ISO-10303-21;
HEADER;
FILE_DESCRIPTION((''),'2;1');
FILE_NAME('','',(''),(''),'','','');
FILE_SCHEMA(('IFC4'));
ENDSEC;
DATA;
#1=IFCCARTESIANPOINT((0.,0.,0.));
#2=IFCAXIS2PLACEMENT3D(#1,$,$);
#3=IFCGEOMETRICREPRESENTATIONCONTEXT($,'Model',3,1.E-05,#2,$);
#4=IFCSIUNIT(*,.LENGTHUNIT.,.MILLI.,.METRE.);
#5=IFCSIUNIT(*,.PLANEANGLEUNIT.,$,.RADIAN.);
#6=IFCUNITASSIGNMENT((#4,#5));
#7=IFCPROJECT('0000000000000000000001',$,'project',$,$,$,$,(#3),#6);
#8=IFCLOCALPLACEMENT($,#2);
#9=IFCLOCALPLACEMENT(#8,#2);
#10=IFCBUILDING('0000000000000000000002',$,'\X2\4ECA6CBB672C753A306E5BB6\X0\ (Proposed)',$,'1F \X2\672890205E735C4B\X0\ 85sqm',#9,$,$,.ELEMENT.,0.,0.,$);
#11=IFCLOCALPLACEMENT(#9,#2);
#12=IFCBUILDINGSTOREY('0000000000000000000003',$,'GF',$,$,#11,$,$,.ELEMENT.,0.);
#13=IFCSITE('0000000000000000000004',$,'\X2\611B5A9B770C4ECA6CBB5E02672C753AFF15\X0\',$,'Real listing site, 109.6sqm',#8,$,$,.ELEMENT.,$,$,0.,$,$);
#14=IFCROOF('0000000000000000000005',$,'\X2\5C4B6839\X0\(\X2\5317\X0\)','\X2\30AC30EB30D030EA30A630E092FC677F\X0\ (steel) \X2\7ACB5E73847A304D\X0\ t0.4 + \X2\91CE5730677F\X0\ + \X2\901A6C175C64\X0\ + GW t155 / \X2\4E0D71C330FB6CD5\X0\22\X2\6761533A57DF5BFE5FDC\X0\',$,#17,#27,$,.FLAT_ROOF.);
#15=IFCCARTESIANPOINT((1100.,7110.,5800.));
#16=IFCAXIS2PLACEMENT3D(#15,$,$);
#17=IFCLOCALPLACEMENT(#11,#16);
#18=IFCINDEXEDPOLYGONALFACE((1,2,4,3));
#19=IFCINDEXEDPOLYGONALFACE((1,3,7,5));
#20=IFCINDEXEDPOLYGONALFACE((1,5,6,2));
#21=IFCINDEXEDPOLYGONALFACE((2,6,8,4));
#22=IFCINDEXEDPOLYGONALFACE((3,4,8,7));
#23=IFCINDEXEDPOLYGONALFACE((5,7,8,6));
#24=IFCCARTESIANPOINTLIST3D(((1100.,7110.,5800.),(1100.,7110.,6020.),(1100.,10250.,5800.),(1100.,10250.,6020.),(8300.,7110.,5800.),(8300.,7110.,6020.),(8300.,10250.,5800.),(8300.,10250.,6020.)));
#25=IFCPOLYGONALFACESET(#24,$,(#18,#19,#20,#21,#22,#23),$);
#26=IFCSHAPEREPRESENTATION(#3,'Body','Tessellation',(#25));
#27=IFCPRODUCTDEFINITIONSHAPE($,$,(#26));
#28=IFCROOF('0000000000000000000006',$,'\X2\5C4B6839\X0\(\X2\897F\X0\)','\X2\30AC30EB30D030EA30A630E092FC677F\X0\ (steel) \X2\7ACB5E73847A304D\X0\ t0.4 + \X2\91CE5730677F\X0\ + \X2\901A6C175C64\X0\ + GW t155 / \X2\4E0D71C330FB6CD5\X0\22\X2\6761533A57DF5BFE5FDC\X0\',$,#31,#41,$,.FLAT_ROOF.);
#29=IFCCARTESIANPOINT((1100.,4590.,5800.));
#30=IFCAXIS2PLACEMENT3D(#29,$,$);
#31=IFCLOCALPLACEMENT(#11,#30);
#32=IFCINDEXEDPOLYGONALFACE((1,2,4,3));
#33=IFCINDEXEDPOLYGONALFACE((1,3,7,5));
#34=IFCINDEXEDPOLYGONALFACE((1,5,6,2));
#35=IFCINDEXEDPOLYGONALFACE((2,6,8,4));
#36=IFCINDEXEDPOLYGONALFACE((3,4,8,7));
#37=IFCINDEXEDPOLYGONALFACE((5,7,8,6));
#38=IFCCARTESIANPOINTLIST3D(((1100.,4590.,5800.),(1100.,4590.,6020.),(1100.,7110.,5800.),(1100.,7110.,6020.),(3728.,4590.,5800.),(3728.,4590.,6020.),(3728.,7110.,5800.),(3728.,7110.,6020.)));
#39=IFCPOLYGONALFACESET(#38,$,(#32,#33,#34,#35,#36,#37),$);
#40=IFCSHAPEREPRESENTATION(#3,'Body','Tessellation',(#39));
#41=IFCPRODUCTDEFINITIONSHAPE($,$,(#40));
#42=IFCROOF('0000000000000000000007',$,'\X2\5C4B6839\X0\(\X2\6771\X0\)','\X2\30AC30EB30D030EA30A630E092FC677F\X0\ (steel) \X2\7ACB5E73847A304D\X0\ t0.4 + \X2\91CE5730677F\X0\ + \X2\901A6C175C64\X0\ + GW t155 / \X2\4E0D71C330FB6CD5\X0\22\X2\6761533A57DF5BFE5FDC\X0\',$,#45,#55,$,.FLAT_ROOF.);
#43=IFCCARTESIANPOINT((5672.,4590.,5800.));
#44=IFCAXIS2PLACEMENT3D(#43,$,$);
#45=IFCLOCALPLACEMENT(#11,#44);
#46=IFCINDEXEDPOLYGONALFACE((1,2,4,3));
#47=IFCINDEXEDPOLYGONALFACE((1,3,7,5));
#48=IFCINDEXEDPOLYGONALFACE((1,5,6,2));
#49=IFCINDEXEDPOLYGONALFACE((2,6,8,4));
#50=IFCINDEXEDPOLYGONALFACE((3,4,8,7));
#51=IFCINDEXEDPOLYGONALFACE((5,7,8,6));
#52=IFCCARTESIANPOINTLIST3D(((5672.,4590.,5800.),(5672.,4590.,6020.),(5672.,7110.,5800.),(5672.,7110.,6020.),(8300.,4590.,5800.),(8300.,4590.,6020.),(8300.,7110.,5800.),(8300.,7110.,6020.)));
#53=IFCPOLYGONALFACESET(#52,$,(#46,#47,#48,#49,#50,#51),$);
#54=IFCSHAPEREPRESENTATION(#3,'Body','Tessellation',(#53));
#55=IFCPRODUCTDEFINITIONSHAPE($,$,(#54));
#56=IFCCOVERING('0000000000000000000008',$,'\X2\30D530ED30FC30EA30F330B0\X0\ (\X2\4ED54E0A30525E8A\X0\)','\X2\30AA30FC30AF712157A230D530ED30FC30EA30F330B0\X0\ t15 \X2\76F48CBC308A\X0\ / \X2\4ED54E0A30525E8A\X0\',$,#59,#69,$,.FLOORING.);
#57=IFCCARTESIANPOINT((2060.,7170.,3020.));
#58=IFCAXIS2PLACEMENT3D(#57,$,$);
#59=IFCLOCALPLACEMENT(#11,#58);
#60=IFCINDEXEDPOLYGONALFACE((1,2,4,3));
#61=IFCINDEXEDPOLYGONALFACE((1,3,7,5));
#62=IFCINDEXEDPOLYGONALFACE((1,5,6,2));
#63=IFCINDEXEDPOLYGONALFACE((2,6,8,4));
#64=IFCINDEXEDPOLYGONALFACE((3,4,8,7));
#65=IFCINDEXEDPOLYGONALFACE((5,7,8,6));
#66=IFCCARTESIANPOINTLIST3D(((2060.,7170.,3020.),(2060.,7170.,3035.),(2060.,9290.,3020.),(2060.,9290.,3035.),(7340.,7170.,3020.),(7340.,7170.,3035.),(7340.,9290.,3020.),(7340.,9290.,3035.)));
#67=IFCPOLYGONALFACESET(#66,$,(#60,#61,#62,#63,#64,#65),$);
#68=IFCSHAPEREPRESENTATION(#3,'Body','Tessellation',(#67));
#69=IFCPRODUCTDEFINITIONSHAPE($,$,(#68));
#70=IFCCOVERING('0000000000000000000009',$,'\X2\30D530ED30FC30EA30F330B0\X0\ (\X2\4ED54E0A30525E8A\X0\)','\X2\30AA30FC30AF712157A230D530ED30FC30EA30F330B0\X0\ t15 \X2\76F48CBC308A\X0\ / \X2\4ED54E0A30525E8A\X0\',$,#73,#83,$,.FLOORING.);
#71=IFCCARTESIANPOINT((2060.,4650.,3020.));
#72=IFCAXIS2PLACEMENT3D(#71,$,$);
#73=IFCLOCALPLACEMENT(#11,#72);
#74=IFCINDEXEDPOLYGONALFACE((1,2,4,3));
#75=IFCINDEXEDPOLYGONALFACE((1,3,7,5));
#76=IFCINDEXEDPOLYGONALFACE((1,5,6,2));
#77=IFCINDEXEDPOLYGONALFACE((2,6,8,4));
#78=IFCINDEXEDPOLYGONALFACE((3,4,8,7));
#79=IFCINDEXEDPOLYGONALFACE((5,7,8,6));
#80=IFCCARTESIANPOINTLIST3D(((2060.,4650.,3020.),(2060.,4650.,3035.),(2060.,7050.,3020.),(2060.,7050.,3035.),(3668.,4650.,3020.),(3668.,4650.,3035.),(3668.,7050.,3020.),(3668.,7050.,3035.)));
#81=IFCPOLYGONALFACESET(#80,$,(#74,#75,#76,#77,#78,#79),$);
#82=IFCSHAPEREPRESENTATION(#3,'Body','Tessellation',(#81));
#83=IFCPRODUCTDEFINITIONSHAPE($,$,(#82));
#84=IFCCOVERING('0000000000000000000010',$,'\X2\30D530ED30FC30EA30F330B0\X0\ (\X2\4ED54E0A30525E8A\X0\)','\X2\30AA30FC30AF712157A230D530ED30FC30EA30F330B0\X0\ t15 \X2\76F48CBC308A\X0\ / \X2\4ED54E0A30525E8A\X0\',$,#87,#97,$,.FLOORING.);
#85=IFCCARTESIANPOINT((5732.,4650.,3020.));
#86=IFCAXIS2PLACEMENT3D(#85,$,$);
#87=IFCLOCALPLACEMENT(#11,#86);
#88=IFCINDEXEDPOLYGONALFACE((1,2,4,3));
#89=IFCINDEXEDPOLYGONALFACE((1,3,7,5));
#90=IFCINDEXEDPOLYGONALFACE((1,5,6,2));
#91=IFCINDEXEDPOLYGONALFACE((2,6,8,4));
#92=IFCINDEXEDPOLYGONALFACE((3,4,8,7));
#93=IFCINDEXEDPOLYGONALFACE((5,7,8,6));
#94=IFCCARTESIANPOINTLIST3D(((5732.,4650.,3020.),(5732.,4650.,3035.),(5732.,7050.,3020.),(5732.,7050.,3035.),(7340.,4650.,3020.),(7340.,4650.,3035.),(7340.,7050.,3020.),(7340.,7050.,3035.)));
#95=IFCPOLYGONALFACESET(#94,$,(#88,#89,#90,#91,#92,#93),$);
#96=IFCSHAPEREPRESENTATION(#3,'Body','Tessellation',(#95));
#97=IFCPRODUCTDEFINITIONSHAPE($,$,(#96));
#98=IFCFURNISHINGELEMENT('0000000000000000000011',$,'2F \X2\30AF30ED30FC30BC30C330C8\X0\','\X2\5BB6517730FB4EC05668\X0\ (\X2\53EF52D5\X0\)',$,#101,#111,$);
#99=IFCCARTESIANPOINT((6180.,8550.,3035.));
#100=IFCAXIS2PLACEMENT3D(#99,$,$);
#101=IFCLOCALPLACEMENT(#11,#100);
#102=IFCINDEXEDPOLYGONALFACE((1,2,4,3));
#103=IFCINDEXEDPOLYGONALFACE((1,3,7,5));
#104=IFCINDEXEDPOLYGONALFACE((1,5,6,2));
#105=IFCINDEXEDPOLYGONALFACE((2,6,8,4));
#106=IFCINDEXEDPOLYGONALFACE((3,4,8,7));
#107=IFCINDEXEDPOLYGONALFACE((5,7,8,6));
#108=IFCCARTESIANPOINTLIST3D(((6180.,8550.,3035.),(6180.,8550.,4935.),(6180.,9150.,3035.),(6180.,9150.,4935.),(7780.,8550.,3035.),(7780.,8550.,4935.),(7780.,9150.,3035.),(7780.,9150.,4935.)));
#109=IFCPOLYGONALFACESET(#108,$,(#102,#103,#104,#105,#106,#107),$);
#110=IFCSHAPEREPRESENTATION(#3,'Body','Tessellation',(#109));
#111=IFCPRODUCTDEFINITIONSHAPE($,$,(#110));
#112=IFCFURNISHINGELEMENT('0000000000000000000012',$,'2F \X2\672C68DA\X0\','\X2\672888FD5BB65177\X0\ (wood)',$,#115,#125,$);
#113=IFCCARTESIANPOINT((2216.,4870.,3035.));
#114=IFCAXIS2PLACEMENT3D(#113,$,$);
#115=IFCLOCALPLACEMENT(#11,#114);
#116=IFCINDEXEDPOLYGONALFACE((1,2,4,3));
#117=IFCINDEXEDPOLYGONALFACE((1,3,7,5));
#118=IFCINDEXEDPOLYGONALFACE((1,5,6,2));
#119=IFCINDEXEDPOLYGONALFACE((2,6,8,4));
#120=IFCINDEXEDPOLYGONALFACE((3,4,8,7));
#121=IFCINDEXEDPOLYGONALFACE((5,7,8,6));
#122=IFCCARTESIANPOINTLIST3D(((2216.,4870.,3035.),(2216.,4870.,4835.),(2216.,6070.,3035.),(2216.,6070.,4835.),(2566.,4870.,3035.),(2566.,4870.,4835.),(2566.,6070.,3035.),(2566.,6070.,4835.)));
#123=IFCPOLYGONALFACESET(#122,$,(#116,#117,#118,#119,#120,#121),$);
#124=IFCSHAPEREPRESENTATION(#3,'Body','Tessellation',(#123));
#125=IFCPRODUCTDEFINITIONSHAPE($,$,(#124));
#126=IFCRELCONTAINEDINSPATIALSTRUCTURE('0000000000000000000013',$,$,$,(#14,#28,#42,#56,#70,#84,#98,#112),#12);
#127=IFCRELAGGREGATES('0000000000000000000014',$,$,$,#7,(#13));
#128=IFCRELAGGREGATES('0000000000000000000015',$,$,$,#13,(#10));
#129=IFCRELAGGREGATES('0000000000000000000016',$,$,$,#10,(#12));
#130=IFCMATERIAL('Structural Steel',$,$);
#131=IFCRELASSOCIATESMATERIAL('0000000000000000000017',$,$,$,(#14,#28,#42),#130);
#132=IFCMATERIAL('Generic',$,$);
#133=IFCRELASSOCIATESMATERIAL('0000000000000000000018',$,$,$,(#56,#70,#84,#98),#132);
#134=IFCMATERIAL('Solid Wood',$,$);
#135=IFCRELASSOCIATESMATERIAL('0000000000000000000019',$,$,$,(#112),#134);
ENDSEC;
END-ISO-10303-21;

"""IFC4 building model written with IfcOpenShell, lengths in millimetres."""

from ifc_helpers import new_model, si_unit, frame, frame_2d, origin, place, context, project, spatial, rectangle, extrude, material, element, save


model = new_model("IFC4")

# Units and contexts
model_context = context("Model", 3, precision=1e-05, world=origin())
ifc_project = project(units=[si_unit("LENGTHUNIT", "METRE", prefix="MILLI"), si_unit("PLANEANGLEUNIT", "RADIAN")], contexts=[model_context])

# Site, building, storey
site_placement = place(None, origin())
site = spatial("IfcSite", under=ifc_project, at=site_placement, Name="愛媛県今治市本町５", ObjectType="Real listing site, 109.6sqm", CompositionType="ELEMENT", RefElevation=0.0)
building_placement = place(site_placement, origin())
building = spatial("IfcBuilding", under=site, at=building_placement, Name="今治本町の家 (Proposed)", ObjectType="1F 木造平屋 85sqm", CompositionType="ELEMENT", ElevationOfRefHeight=0.0, ElevationOfTerrain=0.0)
storey_placement = place(building_placement, origin())
storey = spatial("IfcBuildingStorey", under=building, at=storey_placement, Name="GF", CompositionType="ELEMENT", Elevation=0.0)

# Shared definitions
ifc_material_1 = material(Name="Solid Wood")

# Shared definitions
ifc_material_2 = material(Name="Generic")

# Roofs
ifc_material_3 = material(Name="Structural Steel")
for number, where, name in (
    (1, (1100.0, 7110.0, 5800.0), "屋根(北)"),
):
    element("IfcRoof", number, at=place(storey_placement, frame(where)), inside=storey, material=ifc_material_3, Name=name, Description="ガルバリウム鋼板 (steel) 立平葺き t0.4 + 野地板 + 通気層 + GW t155 / 不燃・法22条区域対応", PredefinedType="FLAT_ROOF", context=model_context, shape_type="SweptSolid", body=[
        extrude(rectangle(XDim=7200.0, YDim=3140.0, at=frame_2d((3600.0, 1570.0))), frame((1100.0, 7110.0, 5800.0)), (0.0, 0.0, 1.0), 220.0),
    ])
roof_1_placement = place(storey_placement, frame((1100.0, 4590.0, 5800.0)))
element("IfcRoof", 2, at=roof_1_placement, inside=storey, material=ifc_material_3, Name="屋根(西)", Description="ガルバリウム鋼板 (steel) 立平葺き t0.4 + 野地板 + 通気層 + GW t155 / 不燃・法22条区域対応", PredefinedType="FLAT_ROOF", context=model_context, shape_type="SweptSolid", body=[
    extrude(rectangle(XDim=2628.0, YDim=2520.0, at=frame_2d((1314.0, 1260.0))), frame((1100.0, 4590.0, 5800.0)), (0.0, 0.0, 1.0), 220.0),
])
roof_2_placement = place(storey_placement, frame((5672.0, 4590.0, 5800.0)))
element("IfcRoof", 3, at=roof_2_placement, inside=storey, material=ifc_material_3, Name="屋根(東)", Description="ガルバリウム鋼板 (steel) 立平葺き t0.4 + 野地板 + 通気層 + GW t155 / 不燃・法22条区域対応", PredefinedType="FLAT_ROOF", context=model_context, shape_type="SweptSolid", body=[
    extrude(rectangle(XDim=2628.0, YDim=2520.0, at=frame_2d((1314.0, 1260.0))), frame((5672.0, 4590.0, 5800.0)), (0.0, 0.0, 1.0), 220.0),
])

# Coverings
covering_1_placement = place(storey_placement, frame((2060.0, 7170.0, 3020.0)))
element("IfcCovering", 4, at=covering_1_placement, inside=storey, material=ifc_material_2, Name="フローリング (仕上げ床)", Description="オーク無垢フローリング t15 直貼り / 仕上げ床", PredefinedType="FLOORING", context=model_context, shape_type="SweptSolid", body=[
    extrude(rectangle(XDim=5280.0, YDim=2120.0, at=frame_2d((2640.0, 1060.0))), frame((2060.0, 7170.0, 3020.0)), (0.0, 0.0, 1.0), 15.0),
])
covering_2_placement = place(storey_placement, frame((2060.0, 4650.0, 3020.0)))
element("IfcCovering", 5, at=covering_2_placement, inside=storey, material=ifc_material_2, Name="フローリング (仕上げ床)", Description="オーク無垢フローリング t15 直貼り / 仕上げ床", PredefinedType="FLOORING", context=model_context, shape_type="SweptSolid", body=[
    extrude(rectangle(XDim=1608.0, YDim=2400.0, at=frame_2d((804.0, 1200.0))), frame((2060.0, 4650.0, 3020.0)), (0.0, 0.0, 1.0), 15.0),
])
covering_3_placement = place(storey_placement, frame((5732.0, 4650.0, 3020.0)))
element("IfcCovering", 6, at=covering_3_placement, inside=storey, material=ifc_material_2, Name="フローリング (仕上げ床)", Description="オーク無垢フローリング t15 直貼り / 仕上げ床", PredefinedType="FLOORING", context=model_context, shape_type="SweptSolid", body=[
    extrude(rectangle(XDim=1608.0, YDim=2400.0, at=frame_2d((804.0, 1200.0))), frame((5732.0, 4650.0, 3020.0)), (0.0, 0.0, 1.0), 15.0),
])

# Furnishing elements
furnishing_1_placement = place(storey_placement, frame((6180.0, 8550.0, 3035.0)))
element("IfcFurnishingElement", 7, at=furnishing_1_placement, inside=storey, material=ifc_material_2, Name="2F クローゼット", Description="家具・什器 (可動)", context=model_context, shape_type="SweptSolid", body=[
    extrude(rectangle(XDim=1600.0, YDim=600.0, at=frame_2d((800.0, 300.0))), frame((6180.0, 8550.0, 3035.0)), (0.0, 0.0, 1.0), 1900.0),
])
furnishing_2_placement = place(storey_placement, frame((2216.0, 4870.0, 3035.0)))
element("IfcFurnishingElement", 8, at=furnishing_2_placement, inside=storey, material=ifc_material_1, Name="2F 本棚", Description="木製家具 (wood)", context=model_context, shape_type="SweptSolid", body=[
    extrude(rectangle(XDim=350.0, YDim=1200.0, at=frame_2d((175.0, 600.0))), frame((2216.0, 4870.0, 3035.0)), (0.0, 0.0, 1.0), 1800.0),
])

save(model, "model.ifc")
